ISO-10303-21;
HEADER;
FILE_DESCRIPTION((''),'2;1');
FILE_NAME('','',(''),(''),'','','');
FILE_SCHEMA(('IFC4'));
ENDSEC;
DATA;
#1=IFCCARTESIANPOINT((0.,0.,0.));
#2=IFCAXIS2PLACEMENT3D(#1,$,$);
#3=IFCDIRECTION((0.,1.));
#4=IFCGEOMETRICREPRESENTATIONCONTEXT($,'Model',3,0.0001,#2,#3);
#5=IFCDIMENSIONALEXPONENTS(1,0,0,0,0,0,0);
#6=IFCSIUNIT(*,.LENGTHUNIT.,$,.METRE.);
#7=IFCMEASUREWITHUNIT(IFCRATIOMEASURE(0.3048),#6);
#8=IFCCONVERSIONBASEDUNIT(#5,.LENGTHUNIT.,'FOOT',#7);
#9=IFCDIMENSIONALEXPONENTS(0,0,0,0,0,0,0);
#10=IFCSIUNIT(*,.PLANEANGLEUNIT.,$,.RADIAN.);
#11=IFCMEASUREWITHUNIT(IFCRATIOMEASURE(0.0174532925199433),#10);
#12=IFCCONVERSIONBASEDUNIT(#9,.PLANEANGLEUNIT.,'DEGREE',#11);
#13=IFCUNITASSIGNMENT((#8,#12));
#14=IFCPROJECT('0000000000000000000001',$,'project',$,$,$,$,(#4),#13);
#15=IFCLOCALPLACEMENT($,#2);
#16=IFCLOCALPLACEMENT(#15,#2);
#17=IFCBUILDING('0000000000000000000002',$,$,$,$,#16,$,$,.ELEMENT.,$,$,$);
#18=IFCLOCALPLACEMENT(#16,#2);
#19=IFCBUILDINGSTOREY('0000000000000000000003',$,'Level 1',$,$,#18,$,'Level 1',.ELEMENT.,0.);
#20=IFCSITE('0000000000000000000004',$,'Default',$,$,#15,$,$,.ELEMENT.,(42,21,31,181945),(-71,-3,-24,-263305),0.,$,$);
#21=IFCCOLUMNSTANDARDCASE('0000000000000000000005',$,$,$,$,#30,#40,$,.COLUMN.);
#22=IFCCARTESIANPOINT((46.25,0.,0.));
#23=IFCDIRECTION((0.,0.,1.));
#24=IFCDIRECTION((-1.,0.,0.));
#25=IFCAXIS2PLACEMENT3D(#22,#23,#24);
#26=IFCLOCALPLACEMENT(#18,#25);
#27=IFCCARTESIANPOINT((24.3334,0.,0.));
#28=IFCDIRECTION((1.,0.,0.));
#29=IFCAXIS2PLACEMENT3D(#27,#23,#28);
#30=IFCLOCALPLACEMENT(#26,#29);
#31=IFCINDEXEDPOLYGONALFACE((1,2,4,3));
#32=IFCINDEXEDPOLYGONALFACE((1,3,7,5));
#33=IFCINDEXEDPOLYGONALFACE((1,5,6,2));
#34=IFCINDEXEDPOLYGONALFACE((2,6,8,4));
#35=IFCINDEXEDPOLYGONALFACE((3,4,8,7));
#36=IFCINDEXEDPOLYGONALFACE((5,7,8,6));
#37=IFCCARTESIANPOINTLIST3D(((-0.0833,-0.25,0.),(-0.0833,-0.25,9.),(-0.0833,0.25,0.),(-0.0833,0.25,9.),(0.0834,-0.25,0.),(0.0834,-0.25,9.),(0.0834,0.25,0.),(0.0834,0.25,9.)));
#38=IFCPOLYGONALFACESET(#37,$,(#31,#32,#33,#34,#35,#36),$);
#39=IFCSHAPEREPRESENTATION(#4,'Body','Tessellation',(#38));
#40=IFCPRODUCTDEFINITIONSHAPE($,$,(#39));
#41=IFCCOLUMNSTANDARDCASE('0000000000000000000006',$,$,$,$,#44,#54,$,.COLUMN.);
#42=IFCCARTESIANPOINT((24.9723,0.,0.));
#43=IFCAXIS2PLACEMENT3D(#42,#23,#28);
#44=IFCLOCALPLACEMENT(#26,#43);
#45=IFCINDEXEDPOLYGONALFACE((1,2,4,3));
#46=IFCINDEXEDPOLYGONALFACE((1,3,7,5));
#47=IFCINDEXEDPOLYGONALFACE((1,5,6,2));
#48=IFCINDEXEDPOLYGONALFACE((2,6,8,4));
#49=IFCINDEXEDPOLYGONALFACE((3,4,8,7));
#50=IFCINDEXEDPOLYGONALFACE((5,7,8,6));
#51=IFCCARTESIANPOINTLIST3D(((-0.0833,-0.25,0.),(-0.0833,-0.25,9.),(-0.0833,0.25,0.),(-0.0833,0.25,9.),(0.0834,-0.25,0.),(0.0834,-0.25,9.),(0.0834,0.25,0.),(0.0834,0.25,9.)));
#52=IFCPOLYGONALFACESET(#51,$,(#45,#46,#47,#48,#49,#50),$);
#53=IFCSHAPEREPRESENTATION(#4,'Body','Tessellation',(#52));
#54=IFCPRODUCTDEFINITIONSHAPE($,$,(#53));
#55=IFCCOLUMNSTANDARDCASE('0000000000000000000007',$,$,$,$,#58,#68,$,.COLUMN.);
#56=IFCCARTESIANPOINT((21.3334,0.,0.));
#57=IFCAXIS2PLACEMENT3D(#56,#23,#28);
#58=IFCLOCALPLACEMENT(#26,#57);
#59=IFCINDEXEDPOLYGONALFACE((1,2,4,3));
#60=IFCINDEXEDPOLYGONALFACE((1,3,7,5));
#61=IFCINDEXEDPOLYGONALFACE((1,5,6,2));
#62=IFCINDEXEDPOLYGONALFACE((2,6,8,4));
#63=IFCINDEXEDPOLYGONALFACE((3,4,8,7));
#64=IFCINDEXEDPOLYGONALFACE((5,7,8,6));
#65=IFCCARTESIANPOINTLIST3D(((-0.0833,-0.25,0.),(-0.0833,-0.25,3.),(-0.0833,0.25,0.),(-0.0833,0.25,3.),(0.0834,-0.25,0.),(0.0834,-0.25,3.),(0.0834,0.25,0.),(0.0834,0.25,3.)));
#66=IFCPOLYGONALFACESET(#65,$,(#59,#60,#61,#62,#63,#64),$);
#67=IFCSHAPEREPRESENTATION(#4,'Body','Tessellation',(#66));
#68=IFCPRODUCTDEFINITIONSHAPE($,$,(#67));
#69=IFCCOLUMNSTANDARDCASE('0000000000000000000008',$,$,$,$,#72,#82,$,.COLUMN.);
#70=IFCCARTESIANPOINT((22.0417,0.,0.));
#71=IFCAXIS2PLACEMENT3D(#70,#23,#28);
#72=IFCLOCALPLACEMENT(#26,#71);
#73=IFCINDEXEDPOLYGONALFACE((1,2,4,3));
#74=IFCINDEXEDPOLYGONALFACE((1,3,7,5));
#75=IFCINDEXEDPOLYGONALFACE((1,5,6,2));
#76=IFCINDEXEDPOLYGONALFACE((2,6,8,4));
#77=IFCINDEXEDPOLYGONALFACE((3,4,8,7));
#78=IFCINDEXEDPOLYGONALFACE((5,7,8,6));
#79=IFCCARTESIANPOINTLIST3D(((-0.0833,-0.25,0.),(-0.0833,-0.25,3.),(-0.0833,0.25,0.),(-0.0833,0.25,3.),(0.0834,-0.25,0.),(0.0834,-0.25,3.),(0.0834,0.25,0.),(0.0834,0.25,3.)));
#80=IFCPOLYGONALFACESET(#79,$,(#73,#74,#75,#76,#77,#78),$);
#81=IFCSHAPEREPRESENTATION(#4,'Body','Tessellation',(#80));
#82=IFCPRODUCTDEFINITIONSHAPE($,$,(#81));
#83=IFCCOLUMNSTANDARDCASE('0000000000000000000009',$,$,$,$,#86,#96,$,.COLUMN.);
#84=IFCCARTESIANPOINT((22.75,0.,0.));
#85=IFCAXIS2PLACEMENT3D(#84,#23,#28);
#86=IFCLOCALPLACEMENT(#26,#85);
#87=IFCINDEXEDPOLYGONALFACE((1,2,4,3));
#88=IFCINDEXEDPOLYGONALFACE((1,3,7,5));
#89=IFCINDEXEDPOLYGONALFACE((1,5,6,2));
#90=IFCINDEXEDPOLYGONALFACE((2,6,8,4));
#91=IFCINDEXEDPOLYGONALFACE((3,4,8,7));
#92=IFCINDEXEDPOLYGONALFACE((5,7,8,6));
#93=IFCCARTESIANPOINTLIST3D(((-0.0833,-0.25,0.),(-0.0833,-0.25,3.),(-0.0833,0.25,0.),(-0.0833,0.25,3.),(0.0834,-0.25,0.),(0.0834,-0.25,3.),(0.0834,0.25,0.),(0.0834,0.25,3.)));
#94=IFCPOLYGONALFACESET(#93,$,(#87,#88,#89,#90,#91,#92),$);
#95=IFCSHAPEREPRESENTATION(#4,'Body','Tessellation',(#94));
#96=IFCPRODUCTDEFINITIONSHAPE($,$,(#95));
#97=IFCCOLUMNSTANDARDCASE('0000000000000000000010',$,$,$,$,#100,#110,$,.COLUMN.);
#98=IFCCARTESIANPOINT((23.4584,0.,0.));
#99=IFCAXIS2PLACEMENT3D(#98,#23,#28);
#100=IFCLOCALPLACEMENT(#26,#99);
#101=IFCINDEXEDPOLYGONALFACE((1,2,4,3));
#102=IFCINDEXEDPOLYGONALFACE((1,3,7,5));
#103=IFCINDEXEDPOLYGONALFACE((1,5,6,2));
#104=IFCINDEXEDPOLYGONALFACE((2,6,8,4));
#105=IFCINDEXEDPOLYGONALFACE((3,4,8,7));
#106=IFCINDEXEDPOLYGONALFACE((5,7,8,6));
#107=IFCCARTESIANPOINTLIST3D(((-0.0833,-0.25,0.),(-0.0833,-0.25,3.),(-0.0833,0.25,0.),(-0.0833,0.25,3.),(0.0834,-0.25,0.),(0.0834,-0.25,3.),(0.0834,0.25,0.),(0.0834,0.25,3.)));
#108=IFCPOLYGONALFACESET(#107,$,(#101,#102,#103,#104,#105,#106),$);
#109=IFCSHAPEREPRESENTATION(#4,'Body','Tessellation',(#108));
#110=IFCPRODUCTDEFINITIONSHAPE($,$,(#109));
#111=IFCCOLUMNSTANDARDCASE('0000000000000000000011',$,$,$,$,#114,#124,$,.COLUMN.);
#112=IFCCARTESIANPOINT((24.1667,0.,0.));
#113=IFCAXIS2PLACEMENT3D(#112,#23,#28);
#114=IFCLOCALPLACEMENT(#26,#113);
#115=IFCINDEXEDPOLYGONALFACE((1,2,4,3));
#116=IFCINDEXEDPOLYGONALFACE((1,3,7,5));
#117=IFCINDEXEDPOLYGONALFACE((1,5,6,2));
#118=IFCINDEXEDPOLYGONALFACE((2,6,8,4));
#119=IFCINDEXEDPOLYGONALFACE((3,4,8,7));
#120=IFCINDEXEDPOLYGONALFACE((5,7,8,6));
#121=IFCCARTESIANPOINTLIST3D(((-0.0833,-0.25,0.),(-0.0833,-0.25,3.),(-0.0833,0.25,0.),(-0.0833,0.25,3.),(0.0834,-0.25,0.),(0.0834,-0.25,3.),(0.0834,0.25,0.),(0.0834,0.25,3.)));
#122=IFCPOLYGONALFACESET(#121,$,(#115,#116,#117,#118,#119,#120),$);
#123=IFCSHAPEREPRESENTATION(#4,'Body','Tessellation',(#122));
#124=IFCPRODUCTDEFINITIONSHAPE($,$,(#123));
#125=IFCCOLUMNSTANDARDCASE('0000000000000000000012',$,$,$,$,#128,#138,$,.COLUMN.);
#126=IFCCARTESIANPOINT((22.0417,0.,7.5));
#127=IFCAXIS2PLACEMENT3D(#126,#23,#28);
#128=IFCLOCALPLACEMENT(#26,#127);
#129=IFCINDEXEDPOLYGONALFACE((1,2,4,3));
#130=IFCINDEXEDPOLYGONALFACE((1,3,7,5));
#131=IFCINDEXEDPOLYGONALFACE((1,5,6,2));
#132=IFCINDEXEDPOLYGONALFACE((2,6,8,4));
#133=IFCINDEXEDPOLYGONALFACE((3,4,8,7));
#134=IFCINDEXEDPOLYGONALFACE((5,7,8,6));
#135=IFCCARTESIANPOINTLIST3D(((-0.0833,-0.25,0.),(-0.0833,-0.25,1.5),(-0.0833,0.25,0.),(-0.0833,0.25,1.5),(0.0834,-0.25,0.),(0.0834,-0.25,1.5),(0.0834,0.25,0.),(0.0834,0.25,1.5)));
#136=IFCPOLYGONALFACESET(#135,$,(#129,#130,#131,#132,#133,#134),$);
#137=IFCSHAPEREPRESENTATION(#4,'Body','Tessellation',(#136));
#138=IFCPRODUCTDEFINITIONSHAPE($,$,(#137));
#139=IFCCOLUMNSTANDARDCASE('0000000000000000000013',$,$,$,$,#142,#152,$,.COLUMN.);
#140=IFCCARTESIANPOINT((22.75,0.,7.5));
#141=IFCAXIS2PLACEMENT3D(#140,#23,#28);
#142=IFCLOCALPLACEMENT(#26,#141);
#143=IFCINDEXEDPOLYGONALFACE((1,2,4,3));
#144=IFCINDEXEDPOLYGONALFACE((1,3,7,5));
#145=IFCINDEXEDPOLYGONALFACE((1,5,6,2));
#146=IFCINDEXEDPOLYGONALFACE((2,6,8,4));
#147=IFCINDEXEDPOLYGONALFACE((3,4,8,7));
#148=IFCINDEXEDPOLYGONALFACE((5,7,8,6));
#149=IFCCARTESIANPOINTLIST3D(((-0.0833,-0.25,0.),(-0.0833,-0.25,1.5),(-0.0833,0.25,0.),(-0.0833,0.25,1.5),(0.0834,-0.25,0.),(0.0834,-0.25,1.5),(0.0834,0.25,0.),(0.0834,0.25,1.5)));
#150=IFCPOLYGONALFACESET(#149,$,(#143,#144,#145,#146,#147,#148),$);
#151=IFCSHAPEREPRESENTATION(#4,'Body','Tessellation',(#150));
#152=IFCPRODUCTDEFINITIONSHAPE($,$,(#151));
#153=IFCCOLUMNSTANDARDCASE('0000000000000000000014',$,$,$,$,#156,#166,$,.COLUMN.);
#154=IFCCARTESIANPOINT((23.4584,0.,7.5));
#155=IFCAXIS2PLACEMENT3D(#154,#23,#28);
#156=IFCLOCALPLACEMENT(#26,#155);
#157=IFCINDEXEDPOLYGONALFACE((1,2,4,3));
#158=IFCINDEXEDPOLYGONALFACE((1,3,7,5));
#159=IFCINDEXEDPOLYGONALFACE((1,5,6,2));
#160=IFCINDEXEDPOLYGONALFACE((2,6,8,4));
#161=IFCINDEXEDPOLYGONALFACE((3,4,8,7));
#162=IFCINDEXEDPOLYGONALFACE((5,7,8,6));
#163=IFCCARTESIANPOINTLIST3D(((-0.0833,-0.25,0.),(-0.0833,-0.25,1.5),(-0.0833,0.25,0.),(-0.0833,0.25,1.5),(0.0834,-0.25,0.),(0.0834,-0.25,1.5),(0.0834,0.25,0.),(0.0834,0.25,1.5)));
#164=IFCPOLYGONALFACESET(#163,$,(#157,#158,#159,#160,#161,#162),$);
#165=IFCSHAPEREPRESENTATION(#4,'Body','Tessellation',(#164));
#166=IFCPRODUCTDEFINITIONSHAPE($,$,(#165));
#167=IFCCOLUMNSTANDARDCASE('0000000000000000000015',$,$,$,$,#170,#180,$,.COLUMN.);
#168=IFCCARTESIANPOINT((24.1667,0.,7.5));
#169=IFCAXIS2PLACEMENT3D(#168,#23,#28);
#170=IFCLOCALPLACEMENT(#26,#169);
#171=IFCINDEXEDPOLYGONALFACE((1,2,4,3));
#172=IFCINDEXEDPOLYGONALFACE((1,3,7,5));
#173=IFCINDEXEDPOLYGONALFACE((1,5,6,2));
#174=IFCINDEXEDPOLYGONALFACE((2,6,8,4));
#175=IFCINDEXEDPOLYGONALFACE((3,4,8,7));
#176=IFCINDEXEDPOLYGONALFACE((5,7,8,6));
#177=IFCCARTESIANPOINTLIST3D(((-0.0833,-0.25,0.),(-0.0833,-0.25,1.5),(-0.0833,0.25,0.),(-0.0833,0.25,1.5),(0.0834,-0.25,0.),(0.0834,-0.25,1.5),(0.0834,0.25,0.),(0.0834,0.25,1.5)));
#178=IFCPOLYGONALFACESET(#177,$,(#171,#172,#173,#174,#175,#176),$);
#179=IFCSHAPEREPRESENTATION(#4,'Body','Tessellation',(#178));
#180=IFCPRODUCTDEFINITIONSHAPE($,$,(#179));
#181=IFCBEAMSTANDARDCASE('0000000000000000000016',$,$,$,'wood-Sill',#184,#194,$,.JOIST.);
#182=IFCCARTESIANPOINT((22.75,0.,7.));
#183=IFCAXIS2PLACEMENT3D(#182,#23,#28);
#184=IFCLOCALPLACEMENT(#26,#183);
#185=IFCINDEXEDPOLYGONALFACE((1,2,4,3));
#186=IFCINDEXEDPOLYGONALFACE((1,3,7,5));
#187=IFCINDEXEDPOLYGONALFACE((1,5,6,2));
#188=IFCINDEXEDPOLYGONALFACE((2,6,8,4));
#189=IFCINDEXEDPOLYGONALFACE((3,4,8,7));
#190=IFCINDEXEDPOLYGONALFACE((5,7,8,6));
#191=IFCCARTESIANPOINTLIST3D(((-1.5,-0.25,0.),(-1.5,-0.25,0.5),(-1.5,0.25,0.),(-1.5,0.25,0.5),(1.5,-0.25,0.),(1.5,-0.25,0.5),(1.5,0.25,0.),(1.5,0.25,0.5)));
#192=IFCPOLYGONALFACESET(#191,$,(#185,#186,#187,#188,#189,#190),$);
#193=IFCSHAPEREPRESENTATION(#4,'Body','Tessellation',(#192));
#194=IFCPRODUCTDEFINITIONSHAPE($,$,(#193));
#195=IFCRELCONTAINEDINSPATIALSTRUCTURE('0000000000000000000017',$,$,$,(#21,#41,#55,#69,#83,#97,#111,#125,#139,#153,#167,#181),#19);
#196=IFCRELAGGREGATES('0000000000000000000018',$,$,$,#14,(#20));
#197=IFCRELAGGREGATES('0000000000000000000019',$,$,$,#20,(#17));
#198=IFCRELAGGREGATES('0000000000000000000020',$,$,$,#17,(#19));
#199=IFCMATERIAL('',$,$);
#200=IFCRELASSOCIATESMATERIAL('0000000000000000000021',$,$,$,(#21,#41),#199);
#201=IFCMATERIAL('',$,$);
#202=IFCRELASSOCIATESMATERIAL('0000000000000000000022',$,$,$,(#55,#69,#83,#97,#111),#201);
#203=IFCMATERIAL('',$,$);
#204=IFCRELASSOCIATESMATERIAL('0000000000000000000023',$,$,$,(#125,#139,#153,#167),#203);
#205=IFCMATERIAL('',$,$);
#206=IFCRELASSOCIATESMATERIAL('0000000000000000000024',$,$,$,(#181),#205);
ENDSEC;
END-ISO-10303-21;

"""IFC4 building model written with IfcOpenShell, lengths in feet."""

from ifc_helpers import new_model, entity, si_unit, converted_unit, direction, frame, origin, place, context, project, spatial, rectangle, extrude, material, element, save


model = new_model("IFC4")

# Units and contexts
model_context = context("Model", 3, precision=0.0001, world=origin(), true_north=direction((0.0, 1.0)))
ifc_project = project(units=[converted_unit("LENGTHUNIT", "FOOT", entity("IfcRatioMeasure", 0.3048), si_unit("LENGTHUNIT", "METRE"), dimensions=[1, 0, 0, 0, 0, 0, 0]), converted_unit("PLANEANGLEUNIT", "DEGREE", entity("IfcRatioMeasure", 0.0174532925199433), si_unit("PLANEANGLEUNIT", "RADIAN"), dimensions=[0, 0, 0, 0, 0, 0, 0])], contexts=[model_context])

# Site, building, storey
site_placement = place(None, origin())
site = spatial("IfcSite", under=ifc_project, at=site_placement, Name="Default", CompositionType="ELEMENT", RefLatitude=(42, 21, 31, 181945), RefLongitude=(-71, -3, -24, -263305), RefElevation=0.0)
building_placement = place(site_placement, origin())
building = spatial("IfcBuilding", under=site, at=building_placement, CompositionType="ELEMENT")
storey_placement = place(building_placement, origin())
storey = spatial("IfcBuildingStorey", under=building, at=storey_placement, Name="Level 1", LongName="Level 1", CompositionType="ELEMENT", Elevation=0.0)

# Columns
ifc_material_1 = material(Name="")
placement = place(storey_placement, frame((46.25, 0.0, 0.0), z_axis=(0.0, 0.0, 1.0), x_axis=(-1.0, 0.0, 0.0)))
for number, where, z_axis, x_axis in (
    (1, (24.3334, 0.0, 0.0), (0.0, 0.0, 1.0), (1.0, 0.0, 0.0)),
    (2, (24.9723, 0.0, 0.0), (0.0, 0.0, 1.0), (1.0, 0.0, 0.0)),
):
    element("IfcColumnStandardCase", number, at=place(placement, frame(where, z_axis=z_axis, x_axis=x_axis)), inside=storey, material=ifc_material_1, PredefinedType="COLUMN", context=model_context, shape_type="SweptSolid", body=[
        extrude(rectangle(XDim=0.1667, YDim=0.5), origin(), (0.0, 0.0, 1.0), 9.0),
    ])
ifc_material_2 = material(Name="")
for number, where, z_axis, x_axis in (
    (3, (21.3334, 0.0, 0.0), (0.0, 0.0, 1.0), (1.0, 0.0, 0.0)),
    (4, (22.0417, 0.0, 0.0), (0.0, 0.0, 1.0), (1.0, 0.0, 0.0)),
    (5, (22.75, 0.0, 0.0), (0.0, 0.0, 1.0), (1.0, 0.0, 0.0)),
    (6, (23.4584, 0.0, 0.0), (0.0, 0.0, 1.0), (1.0, 0.0, 0.0)),
    (7, (24.1667, 0.0, 0.0), (0.0, 0.0, 1.0), (1.0, 0.0, 0.0)),
):
    element("IfcColumnStandardCase", number, at=place(placement, frame(where, z_axis=z_axis, x_axis=x_axis)), inside=storey, material=ifc_material_2, PredefinedType="COLUMN", context=model_context, shape_type="SweptSolid", body=[
        extrude(rectangle(XDim=0.1667, YDim=0.5), origin(), (0.0, 0.0, 1.0), 3.0),
    ])
ifc_material_3 = material(Name="")
for number, where, z_axis, x_axis in (
    (8, (22.0417, 0.0, 7.5), (0.0, 0.0, 1.0), (1.0, 0.0, 0.0)),
    (9, (22.75, 0.0, 7.5), (0.0, 0.0, 1.0), (1.0, 0.0, 0.0)),
    (10, (23.4584, 0.0, 7.5), (0.0, 0.0, 1.0), (1.0, 0.0, 0.0)),
    (11, (24.1667, 0.0, 7.5), (0.0, 0.0, 1.0), (1.0, 0.0, 0.0)),
):
    element("IfcColumnStandardCase", number, at=place(placement, frame(where, z_axis=z_axis, x_axis=x_axis)), inside=storey, material=ifc_material_3, PredefinedType="COLUMN", context=model_context, shape_type="SweptSolid", body=[
        extrude(rectangle(XDim=0.1667, YDim=0.5), origin(), (0.0, 0.0, 1.0), 1.5),
    ])

# Beam
ifc_material_4 = material(Name="")
for number, where, z_axis, x_axis in (
    (12, (22.75, 0.0, 7.0), (0.0, 0.0, 1.0), (1.0, 0.0, 0.0)),
):
    element("IfcBeamStandardCase", number, at=place(placement, frame(where, z_axis=z_axis, x_axis=x_axis)), inside=storey, material=ifc_material_4, ObjectType="wood-Sill", PredefinedType="JOIST", context=model_context, shape_type="SweptSolid", body=[
        extrude(rectangle(XDim=3.0, YDim=0.5), origin(), (0.0, 0.0, 1.0), 0.5),
    ])

save(model, "model.ifc")
